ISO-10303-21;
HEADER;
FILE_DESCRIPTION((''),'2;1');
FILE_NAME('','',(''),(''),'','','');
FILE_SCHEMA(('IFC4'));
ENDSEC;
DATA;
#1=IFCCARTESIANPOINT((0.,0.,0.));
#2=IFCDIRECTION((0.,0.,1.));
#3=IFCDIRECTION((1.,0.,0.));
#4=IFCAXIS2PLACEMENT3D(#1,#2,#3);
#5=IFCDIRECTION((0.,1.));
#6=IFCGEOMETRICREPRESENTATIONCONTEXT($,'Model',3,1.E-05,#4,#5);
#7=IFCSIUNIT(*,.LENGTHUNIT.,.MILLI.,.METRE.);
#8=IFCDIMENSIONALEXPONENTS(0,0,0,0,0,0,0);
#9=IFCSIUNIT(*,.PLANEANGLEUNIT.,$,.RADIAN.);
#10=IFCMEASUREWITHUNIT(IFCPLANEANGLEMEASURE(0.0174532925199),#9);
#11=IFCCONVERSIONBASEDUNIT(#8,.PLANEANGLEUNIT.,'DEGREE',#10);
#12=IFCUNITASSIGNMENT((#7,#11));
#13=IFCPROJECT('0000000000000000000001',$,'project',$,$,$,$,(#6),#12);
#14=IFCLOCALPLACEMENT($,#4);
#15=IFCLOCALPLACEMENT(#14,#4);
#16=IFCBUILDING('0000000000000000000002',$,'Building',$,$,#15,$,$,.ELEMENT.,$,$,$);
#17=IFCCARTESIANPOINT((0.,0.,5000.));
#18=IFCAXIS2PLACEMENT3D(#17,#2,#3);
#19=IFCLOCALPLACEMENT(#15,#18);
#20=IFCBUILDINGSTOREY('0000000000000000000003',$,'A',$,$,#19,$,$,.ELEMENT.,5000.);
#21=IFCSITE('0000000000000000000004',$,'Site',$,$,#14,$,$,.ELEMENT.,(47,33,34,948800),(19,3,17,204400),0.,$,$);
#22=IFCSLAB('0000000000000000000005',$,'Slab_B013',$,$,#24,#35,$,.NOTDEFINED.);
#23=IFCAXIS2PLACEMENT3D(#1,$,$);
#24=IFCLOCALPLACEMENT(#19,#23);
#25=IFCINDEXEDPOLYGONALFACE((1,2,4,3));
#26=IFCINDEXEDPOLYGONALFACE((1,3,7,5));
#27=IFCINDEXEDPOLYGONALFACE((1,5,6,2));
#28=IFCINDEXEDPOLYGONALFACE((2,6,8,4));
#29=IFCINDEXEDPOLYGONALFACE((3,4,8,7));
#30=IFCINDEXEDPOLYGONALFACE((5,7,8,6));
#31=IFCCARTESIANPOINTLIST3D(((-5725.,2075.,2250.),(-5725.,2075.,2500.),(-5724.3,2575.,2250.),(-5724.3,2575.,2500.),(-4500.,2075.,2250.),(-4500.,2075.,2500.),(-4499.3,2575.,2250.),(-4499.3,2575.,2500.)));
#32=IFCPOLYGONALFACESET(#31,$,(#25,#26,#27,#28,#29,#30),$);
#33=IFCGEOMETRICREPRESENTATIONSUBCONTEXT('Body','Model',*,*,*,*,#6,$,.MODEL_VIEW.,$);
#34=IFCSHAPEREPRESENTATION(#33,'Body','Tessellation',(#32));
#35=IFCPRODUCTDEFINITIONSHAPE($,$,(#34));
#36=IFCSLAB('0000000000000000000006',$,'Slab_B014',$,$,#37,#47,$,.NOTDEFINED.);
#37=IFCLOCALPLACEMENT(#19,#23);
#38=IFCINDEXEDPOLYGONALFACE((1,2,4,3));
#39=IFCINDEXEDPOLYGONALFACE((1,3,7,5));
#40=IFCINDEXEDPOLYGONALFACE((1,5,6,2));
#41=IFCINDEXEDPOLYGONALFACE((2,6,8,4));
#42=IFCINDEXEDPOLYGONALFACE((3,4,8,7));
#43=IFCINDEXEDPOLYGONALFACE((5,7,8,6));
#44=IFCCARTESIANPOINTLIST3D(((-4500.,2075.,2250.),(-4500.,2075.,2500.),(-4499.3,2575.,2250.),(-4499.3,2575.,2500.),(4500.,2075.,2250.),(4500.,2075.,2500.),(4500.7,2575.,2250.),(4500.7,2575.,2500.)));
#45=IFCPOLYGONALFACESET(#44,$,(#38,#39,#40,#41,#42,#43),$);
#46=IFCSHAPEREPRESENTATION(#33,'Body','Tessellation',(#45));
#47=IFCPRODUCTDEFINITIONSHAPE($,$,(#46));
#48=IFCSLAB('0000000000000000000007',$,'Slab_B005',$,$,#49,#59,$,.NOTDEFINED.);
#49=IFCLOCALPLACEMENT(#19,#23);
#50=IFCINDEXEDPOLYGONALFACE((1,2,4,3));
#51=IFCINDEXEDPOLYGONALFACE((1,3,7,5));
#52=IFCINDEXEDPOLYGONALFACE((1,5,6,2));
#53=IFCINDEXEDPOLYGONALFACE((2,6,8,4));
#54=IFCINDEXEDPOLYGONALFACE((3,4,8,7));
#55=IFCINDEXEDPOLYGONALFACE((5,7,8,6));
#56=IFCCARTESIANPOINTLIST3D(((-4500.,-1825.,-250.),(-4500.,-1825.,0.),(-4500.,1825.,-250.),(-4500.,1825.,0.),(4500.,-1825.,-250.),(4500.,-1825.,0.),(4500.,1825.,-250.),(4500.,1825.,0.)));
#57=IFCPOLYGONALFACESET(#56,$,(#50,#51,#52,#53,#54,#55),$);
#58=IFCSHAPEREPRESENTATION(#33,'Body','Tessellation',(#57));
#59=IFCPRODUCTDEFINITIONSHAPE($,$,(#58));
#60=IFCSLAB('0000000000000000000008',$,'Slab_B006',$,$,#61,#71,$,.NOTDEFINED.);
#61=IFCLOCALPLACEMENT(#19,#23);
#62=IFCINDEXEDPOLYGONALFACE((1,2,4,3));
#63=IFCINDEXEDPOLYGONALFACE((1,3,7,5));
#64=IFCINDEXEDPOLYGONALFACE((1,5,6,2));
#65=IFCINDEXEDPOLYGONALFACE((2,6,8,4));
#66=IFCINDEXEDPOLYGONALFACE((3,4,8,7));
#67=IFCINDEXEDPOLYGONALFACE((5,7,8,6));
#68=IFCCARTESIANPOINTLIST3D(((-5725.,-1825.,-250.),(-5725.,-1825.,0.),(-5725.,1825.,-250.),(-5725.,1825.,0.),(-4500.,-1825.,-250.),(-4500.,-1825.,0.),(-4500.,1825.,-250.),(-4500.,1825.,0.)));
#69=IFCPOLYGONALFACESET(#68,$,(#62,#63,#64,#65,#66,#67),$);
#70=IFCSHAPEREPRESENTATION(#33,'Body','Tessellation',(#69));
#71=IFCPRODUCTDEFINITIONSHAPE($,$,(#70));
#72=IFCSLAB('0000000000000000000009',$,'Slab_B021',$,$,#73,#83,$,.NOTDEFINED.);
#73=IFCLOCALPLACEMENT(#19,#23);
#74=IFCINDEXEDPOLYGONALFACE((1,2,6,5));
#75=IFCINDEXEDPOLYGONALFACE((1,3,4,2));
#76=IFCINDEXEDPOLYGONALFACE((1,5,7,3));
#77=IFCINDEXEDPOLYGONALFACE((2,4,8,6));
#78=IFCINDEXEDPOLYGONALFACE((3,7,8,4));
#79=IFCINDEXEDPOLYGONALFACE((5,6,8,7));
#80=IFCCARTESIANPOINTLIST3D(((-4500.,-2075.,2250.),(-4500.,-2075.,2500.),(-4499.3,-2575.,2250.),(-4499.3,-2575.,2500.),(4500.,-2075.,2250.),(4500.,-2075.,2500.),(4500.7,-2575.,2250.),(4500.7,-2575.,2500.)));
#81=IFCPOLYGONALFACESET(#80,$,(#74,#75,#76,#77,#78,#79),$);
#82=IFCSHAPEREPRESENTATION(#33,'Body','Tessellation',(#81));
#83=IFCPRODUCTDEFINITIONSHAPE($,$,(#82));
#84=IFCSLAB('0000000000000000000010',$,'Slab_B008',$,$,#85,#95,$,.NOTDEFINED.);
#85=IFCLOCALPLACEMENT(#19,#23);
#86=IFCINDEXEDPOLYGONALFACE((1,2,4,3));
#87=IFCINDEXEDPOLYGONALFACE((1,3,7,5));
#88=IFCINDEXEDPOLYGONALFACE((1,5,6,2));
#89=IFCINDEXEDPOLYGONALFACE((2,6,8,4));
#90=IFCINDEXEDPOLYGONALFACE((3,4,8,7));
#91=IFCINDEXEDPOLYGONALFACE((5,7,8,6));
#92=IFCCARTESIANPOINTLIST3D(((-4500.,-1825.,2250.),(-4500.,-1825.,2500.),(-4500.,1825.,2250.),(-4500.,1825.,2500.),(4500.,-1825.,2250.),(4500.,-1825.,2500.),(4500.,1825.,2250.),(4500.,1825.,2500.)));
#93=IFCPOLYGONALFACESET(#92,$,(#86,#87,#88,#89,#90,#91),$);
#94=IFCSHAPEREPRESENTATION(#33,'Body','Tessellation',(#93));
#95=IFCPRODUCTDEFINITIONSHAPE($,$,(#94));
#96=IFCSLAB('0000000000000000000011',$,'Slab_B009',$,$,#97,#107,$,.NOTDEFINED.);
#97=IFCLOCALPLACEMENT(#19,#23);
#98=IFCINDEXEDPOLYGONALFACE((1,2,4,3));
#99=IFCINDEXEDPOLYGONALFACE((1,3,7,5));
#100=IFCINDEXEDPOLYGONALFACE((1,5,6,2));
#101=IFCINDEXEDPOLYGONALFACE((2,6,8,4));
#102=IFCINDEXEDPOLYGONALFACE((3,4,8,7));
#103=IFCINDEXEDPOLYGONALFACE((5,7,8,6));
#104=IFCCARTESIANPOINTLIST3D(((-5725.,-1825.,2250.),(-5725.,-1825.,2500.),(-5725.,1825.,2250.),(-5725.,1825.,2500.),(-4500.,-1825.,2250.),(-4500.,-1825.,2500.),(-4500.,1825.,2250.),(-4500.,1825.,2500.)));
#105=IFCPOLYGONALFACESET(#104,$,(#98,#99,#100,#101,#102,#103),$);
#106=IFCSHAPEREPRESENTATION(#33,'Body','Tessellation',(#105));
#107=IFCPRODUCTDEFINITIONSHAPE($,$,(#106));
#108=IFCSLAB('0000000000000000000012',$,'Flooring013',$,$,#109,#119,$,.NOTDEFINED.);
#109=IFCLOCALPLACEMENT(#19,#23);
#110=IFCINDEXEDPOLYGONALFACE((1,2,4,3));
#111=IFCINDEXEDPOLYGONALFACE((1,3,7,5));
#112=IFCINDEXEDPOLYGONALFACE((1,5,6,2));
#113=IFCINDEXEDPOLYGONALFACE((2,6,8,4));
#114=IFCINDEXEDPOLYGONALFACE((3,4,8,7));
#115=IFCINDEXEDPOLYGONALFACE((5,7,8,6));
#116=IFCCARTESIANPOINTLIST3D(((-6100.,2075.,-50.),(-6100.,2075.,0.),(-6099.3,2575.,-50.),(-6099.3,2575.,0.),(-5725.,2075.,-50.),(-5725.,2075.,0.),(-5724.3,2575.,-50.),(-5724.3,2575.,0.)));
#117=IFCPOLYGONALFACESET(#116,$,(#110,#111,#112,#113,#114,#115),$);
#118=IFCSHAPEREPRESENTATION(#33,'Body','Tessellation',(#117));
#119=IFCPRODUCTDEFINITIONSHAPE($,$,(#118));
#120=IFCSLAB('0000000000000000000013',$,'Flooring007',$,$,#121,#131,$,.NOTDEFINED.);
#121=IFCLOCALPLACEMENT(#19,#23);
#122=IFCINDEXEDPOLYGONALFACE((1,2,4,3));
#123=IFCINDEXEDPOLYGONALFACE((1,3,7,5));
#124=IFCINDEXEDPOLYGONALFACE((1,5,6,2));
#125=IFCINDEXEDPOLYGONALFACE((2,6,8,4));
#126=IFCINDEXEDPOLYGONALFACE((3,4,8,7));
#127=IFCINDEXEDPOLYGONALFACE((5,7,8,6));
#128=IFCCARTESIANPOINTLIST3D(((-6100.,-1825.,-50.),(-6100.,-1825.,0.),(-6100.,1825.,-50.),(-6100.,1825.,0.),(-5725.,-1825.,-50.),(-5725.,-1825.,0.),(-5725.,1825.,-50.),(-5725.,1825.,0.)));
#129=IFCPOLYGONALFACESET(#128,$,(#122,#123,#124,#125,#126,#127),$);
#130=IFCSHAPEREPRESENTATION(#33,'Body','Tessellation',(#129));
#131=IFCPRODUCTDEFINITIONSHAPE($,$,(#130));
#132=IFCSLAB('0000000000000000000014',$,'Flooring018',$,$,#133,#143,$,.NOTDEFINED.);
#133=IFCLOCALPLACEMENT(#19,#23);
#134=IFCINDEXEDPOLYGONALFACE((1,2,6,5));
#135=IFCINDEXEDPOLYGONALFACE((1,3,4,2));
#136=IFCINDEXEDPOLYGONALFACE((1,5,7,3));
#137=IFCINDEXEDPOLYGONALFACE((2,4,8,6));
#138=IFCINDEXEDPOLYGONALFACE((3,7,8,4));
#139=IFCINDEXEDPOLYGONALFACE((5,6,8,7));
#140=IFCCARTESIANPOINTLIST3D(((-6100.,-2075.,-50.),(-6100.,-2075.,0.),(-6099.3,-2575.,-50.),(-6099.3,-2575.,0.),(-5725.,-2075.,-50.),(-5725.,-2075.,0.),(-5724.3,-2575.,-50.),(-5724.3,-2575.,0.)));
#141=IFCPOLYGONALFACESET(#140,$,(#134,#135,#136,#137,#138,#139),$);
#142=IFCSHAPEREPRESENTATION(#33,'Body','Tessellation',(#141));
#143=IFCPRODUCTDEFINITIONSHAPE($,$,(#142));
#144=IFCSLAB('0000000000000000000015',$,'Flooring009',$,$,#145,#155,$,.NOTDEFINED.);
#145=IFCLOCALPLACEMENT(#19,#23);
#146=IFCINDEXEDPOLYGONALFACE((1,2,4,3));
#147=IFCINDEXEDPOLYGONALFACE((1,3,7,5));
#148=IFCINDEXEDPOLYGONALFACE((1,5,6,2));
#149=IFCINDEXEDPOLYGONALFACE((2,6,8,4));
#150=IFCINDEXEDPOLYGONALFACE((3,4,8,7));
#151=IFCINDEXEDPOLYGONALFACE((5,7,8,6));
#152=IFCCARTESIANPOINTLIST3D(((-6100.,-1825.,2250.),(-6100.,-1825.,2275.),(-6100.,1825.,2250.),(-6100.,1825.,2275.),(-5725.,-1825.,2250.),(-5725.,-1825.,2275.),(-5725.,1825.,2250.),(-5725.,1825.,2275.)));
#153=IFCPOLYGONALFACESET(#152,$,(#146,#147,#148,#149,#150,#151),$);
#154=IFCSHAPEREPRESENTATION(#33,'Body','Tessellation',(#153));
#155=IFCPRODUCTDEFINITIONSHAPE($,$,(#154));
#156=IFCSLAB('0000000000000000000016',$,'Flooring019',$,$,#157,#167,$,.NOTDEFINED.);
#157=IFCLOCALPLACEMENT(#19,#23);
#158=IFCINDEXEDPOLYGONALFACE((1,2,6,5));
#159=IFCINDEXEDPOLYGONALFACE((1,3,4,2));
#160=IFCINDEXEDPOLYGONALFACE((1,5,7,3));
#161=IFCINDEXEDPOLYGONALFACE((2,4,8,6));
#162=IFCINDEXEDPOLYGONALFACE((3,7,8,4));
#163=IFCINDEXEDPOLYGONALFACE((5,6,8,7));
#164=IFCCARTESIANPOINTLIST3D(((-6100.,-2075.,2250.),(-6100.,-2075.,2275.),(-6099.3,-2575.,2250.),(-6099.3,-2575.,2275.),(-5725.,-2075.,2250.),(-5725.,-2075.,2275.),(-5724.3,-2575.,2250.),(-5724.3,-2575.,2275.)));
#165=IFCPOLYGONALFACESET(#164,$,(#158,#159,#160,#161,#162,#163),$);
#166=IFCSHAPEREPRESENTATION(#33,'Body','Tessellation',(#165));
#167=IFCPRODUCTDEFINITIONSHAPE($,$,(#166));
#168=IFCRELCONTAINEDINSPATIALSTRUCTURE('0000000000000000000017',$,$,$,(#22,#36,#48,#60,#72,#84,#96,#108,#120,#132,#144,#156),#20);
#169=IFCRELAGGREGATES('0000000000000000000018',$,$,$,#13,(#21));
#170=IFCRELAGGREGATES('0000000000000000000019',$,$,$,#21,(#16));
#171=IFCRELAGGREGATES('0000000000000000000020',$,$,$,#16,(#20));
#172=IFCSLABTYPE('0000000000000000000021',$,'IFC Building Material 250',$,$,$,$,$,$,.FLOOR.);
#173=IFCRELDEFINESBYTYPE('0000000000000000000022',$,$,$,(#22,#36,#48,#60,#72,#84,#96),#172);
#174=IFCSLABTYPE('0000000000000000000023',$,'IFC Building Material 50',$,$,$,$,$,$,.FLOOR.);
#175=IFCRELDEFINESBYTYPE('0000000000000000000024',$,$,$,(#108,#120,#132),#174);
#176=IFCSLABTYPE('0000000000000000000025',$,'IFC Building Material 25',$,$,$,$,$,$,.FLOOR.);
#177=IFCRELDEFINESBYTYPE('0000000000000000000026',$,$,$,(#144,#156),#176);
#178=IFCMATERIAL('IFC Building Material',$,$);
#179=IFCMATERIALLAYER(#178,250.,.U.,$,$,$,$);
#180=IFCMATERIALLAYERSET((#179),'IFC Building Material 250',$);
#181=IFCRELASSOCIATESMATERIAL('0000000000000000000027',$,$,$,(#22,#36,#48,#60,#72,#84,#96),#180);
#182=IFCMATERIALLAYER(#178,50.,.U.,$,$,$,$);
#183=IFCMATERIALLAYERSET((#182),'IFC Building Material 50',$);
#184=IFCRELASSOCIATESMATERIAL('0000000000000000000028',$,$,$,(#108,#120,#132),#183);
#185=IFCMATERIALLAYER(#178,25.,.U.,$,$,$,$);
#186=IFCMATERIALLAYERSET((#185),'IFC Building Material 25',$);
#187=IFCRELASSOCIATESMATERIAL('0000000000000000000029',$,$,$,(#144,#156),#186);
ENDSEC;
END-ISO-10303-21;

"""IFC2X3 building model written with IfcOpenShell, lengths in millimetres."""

from ifc_helpers import new_model, entity, si_unit, converted_unit, direction, frame, origin_with_axes, place, context, subcontext, project, spatial, polyline, outline, extrude, material, layer, layer_set, layer_usage, type_object, element, save


model = new_model("IFC2X3")

# Units and contexts
model_context = context("Model", 3, precision=1e-05, world=origin_with_axes(), true_north=direction((0.0, 1.0)))
body_context = subcontext(model_context, "Body", "Model", "MODEL_VIEW")
ifc_project = project(units=[si_unit("LENGTHUNIT", "METRE", prefix="MILLI"), converted_unit("PLANEANGLEUNIT", "DEGREE", entity("IfcPlaneAngleMeasure", 0.0174532925199), si_unit("PLANEANGLEUNIT", "RADIAN"), dimensions=[0, 0, 0, 0, 0, 0, 0])], contexts=[model_context])

# Site, building, storey
site_placement = place(None, origin_with_axes())
site = spatial("IfcSite", under=ifc_project, at=site_placement, Name="Site", CompositionType="ELEMENT", RefLatitude=(47, 33, 34, 948800), RefLongitude=(19, 3, 17, 204400), RefElevation=0.0)
building_placement = place(site_placement, origin_with_axes())
building = spatial("IfcBuilding", under=site, at=building_placement, Name="Building", CompositionType="ELEMENT")
storey_placement = place(building_placement, frame((0.0, 0.0, 5000.0), z_axis=(0.0, 0.0, 1.0), x_axis=(1.0, 0.0, 0.0)))
storey = spatial("IfcBuildingStorey", under=building, at=storey_placement, Name="A", CompositionType="ELEMENT", Elevation=5000.0)

# Shared definitions
ifc_material = material(Name="IFC Building Material")

# Slabs
ifc_layer_1 = layer(ifc_material, 250.0, ventilated="UNKNOWN")
ifc_layer_set_1 = layer_set([ifc_layer_1], Name="IFC Building Material 250")
slab_type_1 = type_object("IfcSlabType", Name="IFC Building Material 250", PredefinedType="FLOOR")
ifc_layer_usage_1 = layer_usage(ifc_layer_set_1, "AXIS3", "NEGATIVE", 250.0)
slab_1_placement = place(storey_placement, frame((-5724.3, 2575.0, 2500.0), z_axis=(0.0, 0.0, 1.0), x_axis=(1.0, 0.0, 0.0)))
element("IfcSlab", 1, at=slab_1_placement, inside=storey, type_object=slab_type_1, material=ifc_layer_usage_1, Name="Slab_B013", PredefinedType="NOTDEFINED", context=body_context, shape_type="SweptSolid", body=[
    extrude(outline(polyline([(0.0, 0.0), (-0.7, -500.0), (1224.3, -500.0), (1225.0, 0.0), (0.0, 0.0)])), frame((0.0, 0.0, -250.0), z_axis=(0.0, 0.0, 1.0), x_axis=(1.0, 0.0, 0.0)), (0.0, 0.0, 1.0), 250.0),
])
ifc_layer_usage_2 = layer_usage(ifc_layer_set_1, "AXIS3", "NEGATIVE", 250.0)
slab_2_placement = place(storey_placement, frame((-4499.3, 2575.0, 2500.0), z_axis=(0.0, 0.0, 1.0), x_axis=(1.0, 0.0, 0.0)))
element("IfcSlab", 2, at=slab_2_placement, inside=storey, type_object=slab_type_1, material=ifc_layer_usage_2, Name="Slab_B014", PredefinedType="NOTDEFINED", context=body_context, shape_type="SweptSolid", body=[
    extrude(outline(polyline([(0.0, 0.0), (-0.7, -500.0), (8999.3, -500.0), (9000.0, 0.0), (0.0, 0.0)])), frame((0.0, 0.0, -250.0), z_axis=(0.0, 0.0, 1.0), x_axis=(1.0, 0.0, 0.0)), (0.0, 0.0, 1.0), 250.0),
])
ifc_layer_usage_3 = layer_usage(ifc_layer_set_1, "AXIS3", "NEGATIVE", 250.0)
slab_3_placement = place(storey_placement, frame((-4500.0, -1825.0, 0.0), z_axis=(0.0, 0.0, 1.0), x_axis=(1.0, 0.0, 0.0)))
element("IfcSlab", 3, at=slab_3_placement, inside=storey, type_object=slab_type_1, material=ifc_layer_usage_3, Name="Slab_B005", PredefinedType="NOTDEFINED", context=body_context, shape_type="SweptSolid", body=[
    extrude(outline(polyline([(0.0, 0.0), (9000.0, 0.0), (9000.0, 3650.0), (0.0, 3650.0), (0.0, 0.0)])), frame((0.0, 0.0, -250.0), z_axis=(0.0, 0.0, 1.0), x_axis=(1.0, 0.0, 0.0)), (0.0, 0.0, 1.0), 250.0),
])
ifc_layer_usage_4 = layer_usage(ifc_layer_set_1, "AXIS3", "NEGATIVE", 250.0)
slab_4_placement = place(storey_placement, frame((-5725.0, -1825.0, 0.0), z_axis=(0.0, 0.0, 1.0), x_axis=(1.0, 0.0, 0.0)))
element("IfcSlab", 4, at=slab_4_placement, inside=storey, type_object=slab_type_1, material=ifc_layer_usage_4, Name="Slab_B006", PredefinedType="NOTDEFINED", context=body_context, shape_type="SweptSolid", body=[
    extrude(outline(polyline([(0.0, 0.0), (1225.0, 0.0), (1225.0, 3650.0), (0.0, 3650.0), (0.0, 0.0)])), frame((0.0, 0.0, -250.0), z_axis=(0.0, 0.0, 1.0), x_axis=(1.0, 0.0, 0.0)), (0.0, 0.0, 1.0), 250.0),
])
ifc_layer_usage_5 = layer_usage(ifc_layer_set_1, "AXIS3", "NEGATIVE", 250.0)
slab_5_placement = place(storey_placement, frame((-4499.3, -2575.0, 2500.0), z_axis=(0.0, 0.0, 1.0), x_axis=(1.0, 0.0, 0.0)))
element("IfcSlab", 5, at=slab_5_placement, inside=storey, type_object=slab_type_1, material=ifc_layer_usage_5, Name="Slab_B021", PredefinedType="NOTDEFINED", context=body_context, shape_type="SweptSolid", body=[
    extrude(outline(polyline([(0.0, 0.0), (9000.0, 0.0), (8999.3, 500.0), (-0.7, 500.0), (0.0, 0.0)])), frame((0.0, 0.0, -250.0), z_axis=(0.0, 0.0, 1.0), x_axis=(1.0, 0.0, 0.0)), (0.0, 0.0, 1.0), 250.0),
])
ifc_layer_usage_6 = layer_usage(ifc_layer_set_1, "AXIS3", "NEGATIVE", 250.0)
slab_6_placement = place(storey_placement, frame((-4500.0, -1825.0, 2500.0), z_axis=(0.0, 0.0, 1.0), x_axis=(1.0, 0.0, 0.0)))
element("IfcSlab", 6, at=slab_6_placement, inside=storey, type_object=slab_type_1, material=ifc_layer_usage_6, Name="Slab_B008", PredefinedType="NOTDEFINED", context=body_context, shape_type="SweptSolid", body=[
    extrude(outline(polyline([(0.0, 0.0), (9000.0, 0.0), (9000.0, 3650.0), (0.0, 3650.0), (0.0, 0.0)])), frame((0.0, 0.0, -250.0), z_axis=(0.0, 0.0, 1.0), x_axis=(1.0, 0.0, 0.0)), (0.0, 0.0, 1.0), 250.0),
])
ifc_layer_usage_7 = layer_usage(ifc_layer_set_1, "AXIS3", "NEGATIVE", 250.0)
slab_7_placement = place(storey_placement, frame((-5725.0, -1825.0, 2500.0), z_axis=(0.0, 0.0, 1.0), x_axis=(1.0, 0.0, 0.0)))
element("IfcSlab", 7, at=slab_7_placement, inside=storey, type_object=slab_type_1, material=ifc_layer_usage_7, Name="Slab_B009", PredefinedType="NOTDEFINED", context=body_context, shape_type="SweptSolid", body=[
    extrude(outline(polyline([(0.0, 0.0), (1225.0, 0.0), (1225.0, 3650.0), (0.0, 3650.0), (0.0, 0.0)])), frame((0.0, 0.0, -250.0), z_axis=(0.0, 0.0, 1.0), x_axis=(1.0, 0.0, 0.0)), (0.0, 0.0, 1.0), 250.0),
])
ifc_layer_2 = layer(ifc_material, 50.0, ventilated="UNKNOWN")
ifc_layer_set_2 = layer_set([ifc_layer_2], Name="IFC Building Material 50")
ifc_layer_usage_8 = layer_usage(ifc_layer_set_2, "AXIS3", "NEGATIVE", 50.0)
slab_type_2 = type_object("IfcSlabType", Name="IFC Building Material 50", PredefinedType="FLOOR")
slab_8_placement = place(storey_placement, frame((-6099.3, 2575.0, 0.0), z_axis=(0.0, 0.0, 1.0), x_axis=(1.0, 0.0, 0.0)))
element("IfcSlab", 8, at=slab_8_placement, inside=storey, type_object=slab_type_2, material=ifc_layer_usage_8, Name="Flooring013", PredefinedType="NOTDEFINED", context=body_context, shape_type="SweptSolid", body=[
    extrude(outline(polyline([(0.0, 0.0), (-0.7, -500.0), (374.3, -500.0), (375.0, 0.0), (0.0, 0.0)])), frame((0.0, 0.0, -50.0), z_axis=(0.0, 0.0, 1.0), x_axis=(1.0, 0.0, 0.0)), (0.0, 0.0, 1.0), 50.0),
])
ifc_layer_usage_9 = layer_usage(ifc_layer_set_2, "AXIS3", "NEGATIVE", 50.0)
slab_9_placement = place(storey_placement, frame((-6100.0, -1825.0, 0.0), z_axis=(0.0, 0.0, 1.0), x_axis=(1.0, 0.0, 0.0)))
element("IfcSlab", 9, at=slab_9_placement, inside=storey, type_object=slab_type_2, material=ifc_layer_usage_9, Name="Flooring007", PredefinedType="NOTDEFINED", context=body_context, shape_type="SweptSolid", body=[
    extrude(outline(polyline([(0.0, 0.0), (375.0, 0.0), (375.0, 3650.0), (0.0, 3650.0), (0.0, 0.0)])), frame((0.0, 0.0, -50.0), z_axis=(0.0, 0.0, 1.0), x_axis=(1.0, 0.0, 0.0)), (0.0, 0.0, 1.0), 50.0),
])
ifc_layer_usage_10 = layer_usage(ifc_layer_set_2, "AXIS3", "NEGATIVE", 50.0)
slab_10_placement = place(storey_placement, frame((-6099.3, -2575.0, 0.0), z_axis=(0.0, 0.0, 1.0), x_axis=(1.0, 0.0, 0.0)))
element("IfcSlab", 10, at=slab_10_placement, inside=storey, type_object=slab_type_2, material=ifc_layer_usage_10, Name="Flooring018", PredefinedType="NOTDEFINED", context=body_context, shape_type="SweptSolid", body=[
    extrude(outline(polyline([(0.0, 0.0), (375.0, 0.0), (374.3, 500.0), (-0.7, 500.0), (0.0, 0.0)])), frame((0.0, 0.0, -50.0), z_axis=(0.0, 0.0, 1.0), x_axis=(1.0, 0.0, 0.0)), (0.0, 0.0, 1.0), 50.0),
])
ifc_layer_3 = layer(ifc_material, 25.0, ventilated="UNKNOWN")
ifc_layer_set_3 = layer_set([ifc_layer_3], Name="IFC Building Material 25")
ifc_layer_usage_11 = layer_usage(ifc_layer_set_3, "AXIS3", "NEGATIVE", 25.0)
slab_type_3 = type_object("IfcSlabType", Name="IFC Building Material 25", PredefinedType="FLOOR")
slab_11_placement = place(storey_placement, frame((-6100.0, -1825.0, 2275.0), z_axis=(0.0, 0.0, 1.0), x_axis=(1.0, 0.0, 0.0)))
element("IfcSlab", 11, at=slab_11_placement, inside=storey, type_object=slab_type_3, material=ifc_layer_usage_11, Name="Flooring009", PredefinedType="NOTDEFINED", context=body_context, shape_type="SweptSolid", body=[
    extrude(outline(polyline([(0.0, 0.0), (375.0, 0.0), (375.0, 3650.0), (0.0, 3650.0), (0.0, 0.0)])), frame((0.0, 0.0, -25.0), z_axis=(0.0, 0.0, 1.0), x_axis=(1.0, 0.0, 0.0)), (0.0, 0.0, 1.0), 25.0),
])
ifc_layer_usage_12 = layer_usage(ifc_layer_set_3, "AXIS3", "NEGATIVE", 25.0)
slab_12_placement = place(storey_placement, frame((-6099.3, -2575.0, 2275.0), z_axis=(0.0, 0.0, 1.0), x_axis=(1.0, 0.0, 0.0)))
element("IfcSlab", 12, at=slab_12_placement, inside=storey, type_object=slab_type_3, material=ifc_layer_usage_12, Name="Flooring019", PredefinedType="NOTDEFINED", context=body_context, shape_type="SweptSolid", body=[
    extrude(outline(polyline([(0.0, 0.0), (375.0, 0.0), (374.3, 500.0), (-0.7, 500.0), (0.0, 0.0)])), frame((0.0, 0.0, -25.0), z_axis=(0.0, 0.0, 1.0), x_axis=(1.0, 0.0, 0.0)), (0.0, 0.0, 1.0), 25.0),
])

save(model, "model.ifc")
